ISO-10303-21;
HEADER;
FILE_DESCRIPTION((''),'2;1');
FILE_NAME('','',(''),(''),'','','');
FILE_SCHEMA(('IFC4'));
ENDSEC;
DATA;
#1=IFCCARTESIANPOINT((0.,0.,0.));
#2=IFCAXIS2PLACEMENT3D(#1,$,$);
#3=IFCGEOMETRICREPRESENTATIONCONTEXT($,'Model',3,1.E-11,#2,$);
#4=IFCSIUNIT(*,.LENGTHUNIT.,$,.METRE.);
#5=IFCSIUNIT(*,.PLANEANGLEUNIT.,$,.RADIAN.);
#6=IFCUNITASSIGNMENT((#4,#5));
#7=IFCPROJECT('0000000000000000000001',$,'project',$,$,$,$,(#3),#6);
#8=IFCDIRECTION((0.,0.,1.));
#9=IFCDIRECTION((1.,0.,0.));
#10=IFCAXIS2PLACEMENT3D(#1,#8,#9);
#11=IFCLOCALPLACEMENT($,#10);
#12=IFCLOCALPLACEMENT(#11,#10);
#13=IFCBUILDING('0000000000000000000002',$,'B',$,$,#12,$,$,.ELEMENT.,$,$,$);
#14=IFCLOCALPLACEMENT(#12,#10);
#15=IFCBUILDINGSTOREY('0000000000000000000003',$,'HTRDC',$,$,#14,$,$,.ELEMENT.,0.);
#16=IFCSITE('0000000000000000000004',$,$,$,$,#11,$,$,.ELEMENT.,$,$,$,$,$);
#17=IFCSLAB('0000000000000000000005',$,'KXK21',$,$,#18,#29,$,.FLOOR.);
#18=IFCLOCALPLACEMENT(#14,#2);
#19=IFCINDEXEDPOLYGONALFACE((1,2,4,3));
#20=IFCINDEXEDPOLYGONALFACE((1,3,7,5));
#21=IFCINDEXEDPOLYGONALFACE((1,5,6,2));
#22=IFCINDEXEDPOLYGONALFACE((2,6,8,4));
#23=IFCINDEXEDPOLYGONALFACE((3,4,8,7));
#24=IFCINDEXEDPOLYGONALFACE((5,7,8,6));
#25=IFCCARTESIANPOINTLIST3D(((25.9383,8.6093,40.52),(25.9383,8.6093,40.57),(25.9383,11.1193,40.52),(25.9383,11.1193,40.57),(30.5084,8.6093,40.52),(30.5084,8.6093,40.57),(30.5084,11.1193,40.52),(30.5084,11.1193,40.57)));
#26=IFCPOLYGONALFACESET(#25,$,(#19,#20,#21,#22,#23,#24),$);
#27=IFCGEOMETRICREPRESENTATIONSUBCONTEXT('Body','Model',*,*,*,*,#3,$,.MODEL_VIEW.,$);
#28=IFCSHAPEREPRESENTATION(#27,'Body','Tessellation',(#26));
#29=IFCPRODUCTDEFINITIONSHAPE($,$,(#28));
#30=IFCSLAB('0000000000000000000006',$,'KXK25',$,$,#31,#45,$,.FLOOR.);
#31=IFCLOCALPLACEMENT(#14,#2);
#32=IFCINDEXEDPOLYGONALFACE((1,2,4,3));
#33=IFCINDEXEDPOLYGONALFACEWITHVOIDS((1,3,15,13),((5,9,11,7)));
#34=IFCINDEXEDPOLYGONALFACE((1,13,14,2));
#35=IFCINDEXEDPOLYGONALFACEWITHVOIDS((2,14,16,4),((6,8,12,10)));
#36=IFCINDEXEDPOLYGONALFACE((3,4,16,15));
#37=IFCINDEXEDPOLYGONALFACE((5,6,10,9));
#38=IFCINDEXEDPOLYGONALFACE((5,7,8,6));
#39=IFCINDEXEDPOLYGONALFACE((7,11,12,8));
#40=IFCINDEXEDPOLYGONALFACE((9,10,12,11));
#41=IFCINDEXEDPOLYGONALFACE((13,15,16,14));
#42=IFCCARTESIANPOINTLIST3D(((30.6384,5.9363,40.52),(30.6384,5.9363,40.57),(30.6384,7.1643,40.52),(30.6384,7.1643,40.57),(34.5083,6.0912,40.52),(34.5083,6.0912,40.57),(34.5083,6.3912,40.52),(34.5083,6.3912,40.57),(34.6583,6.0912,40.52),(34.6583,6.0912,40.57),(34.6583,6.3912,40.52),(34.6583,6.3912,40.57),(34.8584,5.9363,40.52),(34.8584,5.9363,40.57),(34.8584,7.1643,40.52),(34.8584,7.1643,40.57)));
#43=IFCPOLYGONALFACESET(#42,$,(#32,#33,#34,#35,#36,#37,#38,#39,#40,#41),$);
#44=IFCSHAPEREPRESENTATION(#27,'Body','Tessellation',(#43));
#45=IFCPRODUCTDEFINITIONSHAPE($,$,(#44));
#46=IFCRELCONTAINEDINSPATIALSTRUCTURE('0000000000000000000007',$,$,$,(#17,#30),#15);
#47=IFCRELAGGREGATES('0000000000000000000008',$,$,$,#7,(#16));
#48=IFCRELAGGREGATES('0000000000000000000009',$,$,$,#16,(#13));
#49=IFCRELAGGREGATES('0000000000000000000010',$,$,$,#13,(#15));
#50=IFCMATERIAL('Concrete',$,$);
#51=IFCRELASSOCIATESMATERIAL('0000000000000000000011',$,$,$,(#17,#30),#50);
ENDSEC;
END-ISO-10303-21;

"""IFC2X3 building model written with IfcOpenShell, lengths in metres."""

from ifc_helpers import new_model, si_unit, frame, origin, origin_with_axes, place, context, subcontext, project, spatial, polyline, outline, extrude, material, element, save


model = new_model("IFC2X3")

# Units and contexts
model_context = context("Model", 3, precision=1e-11, world=origin())
body_context = subcontext(model_context, "Body", "Model", "MODEL_VIEW")
ifc_project = project(units=[si_unit("LENGTHUNIT", "METRE"), si_unit("PLANEANGLEUNIT", "RADIAN")], contexts=[model_context])

# Site, building, storey
site_placement = place(None, origin_with_axes())
site = spatial("IfcSite", under=ifc_project, at=site_placement, CompositionType="ELEMENT")
building_placement = place(site_placement, origin_with_axes())
building = spatial("IfcBuilding", under=site, at=building_placement, Name="B", CompositionType="ELEMENT")
storey_placement = place(building_placement, origin_with_axes())
storey = spatial("IfcBuildingStorey", under=building, at=storey_placement, Name="HTRDC", CompositionType="ELEMENT", Elevation=0.0)

# Slab
ifc_material = material(Name="Concrete")
slab_1_placement = place(storey_placement, frame((25.9383, 8.6093, 40.52), z_axis=(0.0, 0.0, 1.0), x_axis=(1.0, 0.0, 0.0)))
element("IfcSlab", 1, at=slab_1_placement, inside=storey, material=ifc_material, Name="KXK21", PredefinedType="FLOOR", context=body_context, shape_type="SweptSolid", body=[
    extrude(outline(polyline([(0.0, 0.0), (0.0, -4.5701), (2.51, -4.5701), (2.51, 0.0), (0.0, 0.0)])), frame((0.0, 0.0, 0.0), z_axis=(0.0, 0.0, 1.0), x_axis=(0.0, 1.0, 0.0)), (0.0, 0.0, 1.0), 0.05),
])

# Slab, opening
slab_2_placement = place(storey_placement, frame((30.6384, 5.9363, 40.52), z_axis=(0.0, 0.0, 1.0), x_axis=(1.0, 0.0, 0.0)))
slab_2 = element("IfcSlab", 2, at=slab_2_placement, inside=storey, material=ifc_material, Name="KXK25", PredefinedType="FLOOR", context=body_context, shape_type="SweptSolid", body=[
    extrude(outline(polyline([(0.0, 0.0), (0.0, -4.22), (1.228, -4.22), (1.228, 0.0), (0.0, 0.0)])), frame((0.0, 0.0, 0.0), z_axis=(0.0, 0.0, 1.0), x_axis=(0.0, 1.0, 0.0)), (0.0, 0.0, 1.0), 0.05),
])
opening_1_placement = place(slab_2_placement, origin_with_axes())
element("IfcOpeningElement", 3, at=opening_1_placement, cuts=slab_2, ObjectType="Opening", context=body_context, shape_type="SweptSolid", body=[
    extrude(outline(polyline([(0.1549, -3.87), (0.1549, -4.02), (0.4549, -4.02), (0.4549, -3.87), (0.1549, -3.87)])), frame((0.0, 0.0, 0.0), z_axis=(0.0, 0.0, 1.0), x_axis=(0.0, 1.0, 0.0)), (0.0, 0.0, 1.0), 0.05),
])

save(model, "model.ifc")
